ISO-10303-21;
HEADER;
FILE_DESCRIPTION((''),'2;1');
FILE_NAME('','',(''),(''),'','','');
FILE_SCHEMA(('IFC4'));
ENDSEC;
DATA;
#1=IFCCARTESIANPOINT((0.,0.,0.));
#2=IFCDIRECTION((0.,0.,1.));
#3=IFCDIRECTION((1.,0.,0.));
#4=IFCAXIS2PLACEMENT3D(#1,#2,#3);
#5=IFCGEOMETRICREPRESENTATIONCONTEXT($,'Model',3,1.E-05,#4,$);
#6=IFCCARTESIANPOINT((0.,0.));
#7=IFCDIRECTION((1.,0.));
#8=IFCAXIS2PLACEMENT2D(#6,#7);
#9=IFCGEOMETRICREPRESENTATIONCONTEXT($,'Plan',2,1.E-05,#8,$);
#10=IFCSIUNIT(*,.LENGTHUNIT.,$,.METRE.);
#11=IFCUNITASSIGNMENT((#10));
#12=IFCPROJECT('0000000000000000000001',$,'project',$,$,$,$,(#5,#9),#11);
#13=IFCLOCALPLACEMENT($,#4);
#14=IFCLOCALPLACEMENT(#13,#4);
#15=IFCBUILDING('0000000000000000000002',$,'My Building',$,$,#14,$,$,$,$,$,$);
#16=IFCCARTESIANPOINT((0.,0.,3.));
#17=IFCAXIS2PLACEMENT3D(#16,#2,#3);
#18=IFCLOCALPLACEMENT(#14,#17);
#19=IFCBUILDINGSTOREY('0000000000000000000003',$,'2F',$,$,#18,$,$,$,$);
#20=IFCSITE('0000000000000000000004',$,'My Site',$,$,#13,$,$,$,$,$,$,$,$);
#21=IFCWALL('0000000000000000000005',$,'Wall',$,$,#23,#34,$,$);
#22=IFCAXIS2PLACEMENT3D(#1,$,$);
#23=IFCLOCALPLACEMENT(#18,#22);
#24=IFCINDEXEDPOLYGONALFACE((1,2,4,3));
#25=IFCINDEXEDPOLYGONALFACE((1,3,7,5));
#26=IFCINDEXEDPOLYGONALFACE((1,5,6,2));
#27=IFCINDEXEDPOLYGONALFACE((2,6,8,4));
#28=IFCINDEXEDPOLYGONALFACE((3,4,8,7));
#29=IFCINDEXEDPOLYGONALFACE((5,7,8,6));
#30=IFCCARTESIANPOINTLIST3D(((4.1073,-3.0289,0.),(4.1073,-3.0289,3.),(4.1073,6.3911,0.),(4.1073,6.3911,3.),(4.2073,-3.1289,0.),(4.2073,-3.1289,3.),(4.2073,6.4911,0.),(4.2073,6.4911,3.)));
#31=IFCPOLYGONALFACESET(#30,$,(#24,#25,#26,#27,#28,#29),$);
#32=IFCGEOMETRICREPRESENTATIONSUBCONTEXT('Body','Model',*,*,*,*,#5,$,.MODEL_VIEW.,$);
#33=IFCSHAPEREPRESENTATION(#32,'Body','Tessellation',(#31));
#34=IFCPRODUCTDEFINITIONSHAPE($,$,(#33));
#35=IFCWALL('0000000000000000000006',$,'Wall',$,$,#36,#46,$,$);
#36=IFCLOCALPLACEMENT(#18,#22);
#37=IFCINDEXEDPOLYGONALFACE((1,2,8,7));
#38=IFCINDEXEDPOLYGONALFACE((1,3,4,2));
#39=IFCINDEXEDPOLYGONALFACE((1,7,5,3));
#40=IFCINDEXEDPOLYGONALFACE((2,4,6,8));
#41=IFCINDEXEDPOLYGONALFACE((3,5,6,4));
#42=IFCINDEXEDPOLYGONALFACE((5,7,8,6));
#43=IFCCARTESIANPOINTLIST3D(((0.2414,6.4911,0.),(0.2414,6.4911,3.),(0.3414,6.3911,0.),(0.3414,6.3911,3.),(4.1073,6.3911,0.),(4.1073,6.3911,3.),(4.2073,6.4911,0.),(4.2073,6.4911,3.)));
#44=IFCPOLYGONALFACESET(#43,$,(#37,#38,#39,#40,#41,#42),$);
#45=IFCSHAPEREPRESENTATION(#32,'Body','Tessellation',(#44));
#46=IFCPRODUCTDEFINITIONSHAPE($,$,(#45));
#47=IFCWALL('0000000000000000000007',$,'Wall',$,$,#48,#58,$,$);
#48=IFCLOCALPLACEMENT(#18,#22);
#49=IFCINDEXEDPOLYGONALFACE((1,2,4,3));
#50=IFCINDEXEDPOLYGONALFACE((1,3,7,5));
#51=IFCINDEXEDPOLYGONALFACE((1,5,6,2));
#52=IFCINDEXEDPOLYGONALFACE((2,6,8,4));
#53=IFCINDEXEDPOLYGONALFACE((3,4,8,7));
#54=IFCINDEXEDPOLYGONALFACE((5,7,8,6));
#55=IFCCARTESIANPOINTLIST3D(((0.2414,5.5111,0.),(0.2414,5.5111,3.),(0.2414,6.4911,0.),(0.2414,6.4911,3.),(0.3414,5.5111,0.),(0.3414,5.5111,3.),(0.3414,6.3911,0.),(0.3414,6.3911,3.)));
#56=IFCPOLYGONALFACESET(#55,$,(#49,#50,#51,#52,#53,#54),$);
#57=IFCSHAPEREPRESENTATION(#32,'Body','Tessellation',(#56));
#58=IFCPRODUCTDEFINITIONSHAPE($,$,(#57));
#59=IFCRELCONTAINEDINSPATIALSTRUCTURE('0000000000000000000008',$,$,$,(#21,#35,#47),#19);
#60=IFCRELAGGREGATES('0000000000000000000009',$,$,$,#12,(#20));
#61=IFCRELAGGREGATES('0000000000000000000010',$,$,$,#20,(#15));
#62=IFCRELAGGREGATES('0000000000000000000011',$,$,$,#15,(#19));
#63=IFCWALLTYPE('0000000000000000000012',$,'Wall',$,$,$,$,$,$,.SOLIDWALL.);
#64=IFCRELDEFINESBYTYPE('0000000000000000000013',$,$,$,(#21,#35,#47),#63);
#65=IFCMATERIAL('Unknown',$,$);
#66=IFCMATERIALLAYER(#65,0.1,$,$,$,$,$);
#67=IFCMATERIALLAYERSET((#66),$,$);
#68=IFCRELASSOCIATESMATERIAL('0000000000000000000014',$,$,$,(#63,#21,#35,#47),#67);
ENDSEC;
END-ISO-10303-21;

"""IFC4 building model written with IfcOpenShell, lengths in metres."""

from ifc_helpers import new_model, si_unit, frame, origin_with_axes, origin_2d_with_axis, place, context, subcontext, project, spatial, line, indexed_curve, outline, extrude, material, layer, layer_set, layer_usage, type_object, element, save


model = new_model("IFC4")

# Units and contexts
model_context = context("Model", 3, precision=1e-05, world=origin_with_axes())
plan_context = context("Plan", 2, precision=1e-05, world=origin_2d_with_axis())
body_context_1 = subcontext(model_context, "Body", "Model", "MODEL_VIEW")
ifc_project = project(units=[si_unit("LENGTHUNIT", "METRE")], contexts=[model_context, plan_context])

# Site, building, storey
site_placement = place(None, origin_with_axes())
site = spatial("IfcSite", under=ifc_project, at=site_placement, Name="My Site")
building_placement = place(site_placement, origin_with_axes())
building = spatial("IfcBuilding", under=site, at=building_placement, Name="My Building")
storey_placement = place(building_placement, frame((0.0, 0.0, 3.0), z_axis=(0.0, 0.0, 1.0), x_axis=(1.0, 0.0, 0.0)))
storey = spatial("IfcBuildingStorey", under=building, at=storey_placement, Name="2F")

# Walls
ifc_material_1 = material(Name="Unknown")
ifc_layer_1 = layer(ifc_material_1, 0.1)
ifc_layer_set_1 = layer_set([ifc_layer_1])
ifc_layer_usage_1 = layer_usage(ifc_layer_set_1, "AXIS2", "POSITIVE", 0.0)
wall_type_1 = type_object("IfcWallType", Name="Wall", PredefinedType="SOLIDWALL", material=ifc_layer_set_1)
wall_1_placement = place(storey_placement, frame((4.2073, -3.1289, 0.0), z_axis=(0.0, 0.0, 1.0), x_axis=(0.0, 1.0, 0.0)))
element("IfcWall", 1, at=wall_1_placement, inside=storey, type_object=wall_type_1, material=ifc_layer_usage_1, Name="Wall", context=body_context_1, shape_type="SweptSolid", body=[
    extrude(outline(indexed_curve([(0.0, 0.0), (0.1, 0.1), (9.52, 0.1), (9.62, 0.0)], segments=[line(1, 2, 3, 4, 1)])), origin_with_axes(), (0.0, 0.0, 1.0), 3.0),
])
ifc_layer_usage_2 = layer_usage(ifc_layer_set_1, "AXIS2", "POSITIVE", 0.0)
wall_2_placement = place(storey_placement, frame((4.2073, 6.4911, 0.0), z_axis=(0.0, 0.0, 1.0), x_axis=(-1.0, 0.0, 0.0)))
element("IfcWall", 2, at=wall_2_placement, inside=storey, type_object=wall_type_1, material=ifc_layer_usage_2, Name="Wall", context=body_context_1, shape_type="SweptSolid", body=[
    extrude(outline(indexed_curve([(0.0, 0.0), (0.1, 0.1), (3.8658, 0.1), (3.9658, 0.0)], segments=[line(1, 2, 3, 4, 1)])), origin_with_axes(), (0.0, 0.0, 1.0), 3.0),
])
ifc_layer_usage_3 = layer_usage(ifc_layer_set_1, "AXIS2", "POSITIVE", 0.0)
wall_3_placement = place(storey_placement, frame((0.2414, 6.4911, 0.0), z_axis=(0.0, 0.0, 1.0), x_axis=(0.0, -1.0, 0.0)))
element("IfcWall", 3, at=wall_3_placement, inside=storey, type_object=wall_type_1, material=ifc_layer_usage_3, Name="Wall", context=body_context_1, shape_type="SweptSolid", body=[
    extrude(outline(indexed_curve([(0.0, 0.0), (0.1, 0.1), (0.98, 0.1), (0.98, 0.0)], segments=[line(1, 2, 3, 4, 1)])), origin_with_axes(), (0.0, 0.0, 1.0), 3.0),
])

save(model, "model.ifc")
